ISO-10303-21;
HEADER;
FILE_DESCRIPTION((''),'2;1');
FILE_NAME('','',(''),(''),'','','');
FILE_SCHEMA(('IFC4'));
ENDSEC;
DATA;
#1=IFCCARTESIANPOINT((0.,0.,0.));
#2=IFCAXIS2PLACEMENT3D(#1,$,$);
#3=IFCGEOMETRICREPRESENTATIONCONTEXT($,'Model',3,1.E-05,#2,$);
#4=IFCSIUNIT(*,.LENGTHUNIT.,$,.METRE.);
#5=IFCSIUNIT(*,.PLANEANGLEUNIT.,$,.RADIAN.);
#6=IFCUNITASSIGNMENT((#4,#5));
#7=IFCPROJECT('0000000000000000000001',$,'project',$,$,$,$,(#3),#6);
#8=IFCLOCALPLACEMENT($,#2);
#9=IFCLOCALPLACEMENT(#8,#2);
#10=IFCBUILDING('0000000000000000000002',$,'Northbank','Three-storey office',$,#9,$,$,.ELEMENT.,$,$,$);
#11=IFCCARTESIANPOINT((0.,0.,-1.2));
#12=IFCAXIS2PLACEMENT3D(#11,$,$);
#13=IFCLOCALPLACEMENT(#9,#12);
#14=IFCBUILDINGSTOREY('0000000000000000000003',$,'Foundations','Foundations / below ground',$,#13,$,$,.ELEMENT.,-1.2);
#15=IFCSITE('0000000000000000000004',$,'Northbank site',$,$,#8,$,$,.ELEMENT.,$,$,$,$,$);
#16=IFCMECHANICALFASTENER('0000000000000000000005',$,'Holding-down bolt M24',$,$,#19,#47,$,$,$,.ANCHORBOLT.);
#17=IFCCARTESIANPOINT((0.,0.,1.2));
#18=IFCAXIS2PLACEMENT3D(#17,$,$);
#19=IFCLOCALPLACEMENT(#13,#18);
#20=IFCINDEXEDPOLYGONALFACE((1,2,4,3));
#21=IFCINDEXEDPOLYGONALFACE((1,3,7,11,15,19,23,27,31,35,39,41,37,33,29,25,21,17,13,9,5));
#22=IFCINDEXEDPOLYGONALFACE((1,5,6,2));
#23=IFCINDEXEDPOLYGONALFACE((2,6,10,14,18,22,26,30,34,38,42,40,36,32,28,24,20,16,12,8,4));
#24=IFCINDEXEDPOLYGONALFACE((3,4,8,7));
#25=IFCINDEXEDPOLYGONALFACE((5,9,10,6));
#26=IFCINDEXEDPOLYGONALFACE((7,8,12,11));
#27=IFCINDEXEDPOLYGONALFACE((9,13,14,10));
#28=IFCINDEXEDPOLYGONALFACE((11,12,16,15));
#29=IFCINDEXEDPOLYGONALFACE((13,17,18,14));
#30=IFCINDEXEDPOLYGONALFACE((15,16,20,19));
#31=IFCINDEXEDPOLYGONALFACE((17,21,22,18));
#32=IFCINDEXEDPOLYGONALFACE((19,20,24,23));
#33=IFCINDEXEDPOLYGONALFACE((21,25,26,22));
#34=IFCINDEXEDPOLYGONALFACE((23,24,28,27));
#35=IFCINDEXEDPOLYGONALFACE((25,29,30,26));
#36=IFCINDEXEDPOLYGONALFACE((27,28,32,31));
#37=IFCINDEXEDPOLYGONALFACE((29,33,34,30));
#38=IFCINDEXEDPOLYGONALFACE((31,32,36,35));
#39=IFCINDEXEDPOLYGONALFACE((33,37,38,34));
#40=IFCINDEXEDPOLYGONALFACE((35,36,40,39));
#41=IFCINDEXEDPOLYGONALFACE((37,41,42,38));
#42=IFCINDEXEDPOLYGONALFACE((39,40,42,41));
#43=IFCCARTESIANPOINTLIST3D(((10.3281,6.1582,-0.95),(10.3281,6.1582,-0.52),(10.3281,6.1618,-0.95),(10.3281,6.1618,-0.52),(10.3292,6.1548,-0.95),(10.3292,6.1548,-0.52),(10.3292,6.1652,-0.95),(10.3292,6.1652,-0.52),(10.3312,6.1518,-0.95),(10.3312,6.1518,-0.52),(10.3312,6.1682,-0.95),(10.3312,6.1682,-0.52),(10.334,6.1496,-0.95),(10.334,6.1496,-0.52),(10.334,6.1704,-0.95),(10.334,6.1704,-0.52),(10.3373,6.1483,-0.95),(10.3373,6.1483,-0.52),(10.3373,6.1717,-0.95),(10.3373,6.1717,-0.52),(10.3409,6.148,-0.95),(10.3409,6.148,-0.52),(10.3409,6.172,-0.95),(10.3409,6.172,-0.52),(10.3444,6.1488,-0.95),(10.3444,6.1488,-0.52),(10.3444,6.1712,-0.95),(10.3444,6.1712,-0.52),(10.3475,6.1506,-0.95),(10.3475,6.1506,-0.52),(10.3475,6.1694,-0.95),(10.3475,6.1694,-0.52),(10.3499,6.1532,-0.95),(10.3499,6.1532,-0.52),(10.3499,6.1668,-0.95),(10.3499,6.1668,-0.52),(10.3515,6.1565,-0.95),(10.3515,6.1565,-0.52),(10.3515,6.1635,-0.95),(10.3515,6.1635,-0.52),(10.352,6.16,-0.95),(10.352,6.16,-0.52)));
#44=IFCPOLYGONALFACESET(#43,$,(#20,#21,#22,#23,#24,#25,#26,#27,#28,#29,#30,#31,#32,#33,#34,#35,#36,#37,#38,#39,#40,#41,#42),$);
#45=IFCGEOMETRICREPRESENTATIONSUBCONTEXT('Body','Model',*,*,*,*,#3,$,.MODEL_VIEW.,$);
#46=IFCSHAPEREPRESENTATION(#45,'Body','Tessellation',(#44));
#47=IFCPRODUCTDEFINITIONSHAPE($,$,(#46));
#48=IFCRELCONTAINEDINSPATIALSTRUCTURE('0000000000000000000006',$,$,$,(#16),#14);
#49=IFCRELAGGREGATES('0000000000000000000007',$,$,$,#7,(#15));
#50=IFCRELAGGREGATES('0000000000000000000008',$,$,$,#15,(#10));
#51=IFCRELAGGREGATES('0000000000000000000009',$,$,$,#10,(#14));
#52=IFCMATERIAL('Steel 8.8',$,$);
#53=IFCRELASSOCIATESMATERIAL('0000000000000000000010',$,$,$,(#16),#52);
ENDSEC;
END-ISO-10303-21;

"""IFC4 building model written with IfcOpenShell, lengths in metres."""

from ifc_helpers import new_model, si_unit, frame, origin, place, context, subcontext, project, spatial, circle, extrude, material, element, save


model = new_model("IFC4")

# Units and contexts
model_context = context("Model", 3, precision=1e-05, world=origin())
body_context = subcontext(model_context, "Body", "Model", "MODEL_VIEW")
ifc_project = project(units=[si_unit("LENGTHUNIT", "METRE"), si_unit("PLANEANGLEUNIT", "RADIAN")], contexts=[model_context])

# Site, building, storey
site_placement = place(None, origin())
site = spatial("IfcSite", under=ifc_project, at=site_placement, Name="Northbank site", CompositionType="ELEMENT")
building_placement = place(site_placement, origin())
building = spatial("IfcBuilding", under=site, at=building_placement, Name="Northbank", Description="Three-storey office", CompositionType="ELEMENT")
storey_placement = place(building_placement, frame((0.0, 0.0, -1.2)))
storey = spatial("IfcBuildingStorey", under=building, at=storey_placement, Name="Foundations", Description="Foundations / below ground", CompositionType="ELEMENT", Elevation=-1.2)

# Mechanical fastener
ifc_material_1 = material(Name="Steel 8.8")
mechanical_fastener_1_placement = place(storey_placement, frame((0.0, 0.0, 1.2)))
element("IfcMechanicalFastener", 1, at=mechanical_fastener_1_placement, inside=storey, material=ifc_material_1, Name="Holding-down bolt M24", PredefinedType="ANCHORBOLT", context=body_context, shape_type="SweptSolid", body=[
    extrude(circle(Radius=0.012), frame((10.34, 6.16, -0.95), z_axis=(0.0, 0.0, 1.0), x_axis=(1.0, 0.0, 0.0)), (0.0, 0.0, 1.0), 0.43),
])

save(model, "model.ifc")
